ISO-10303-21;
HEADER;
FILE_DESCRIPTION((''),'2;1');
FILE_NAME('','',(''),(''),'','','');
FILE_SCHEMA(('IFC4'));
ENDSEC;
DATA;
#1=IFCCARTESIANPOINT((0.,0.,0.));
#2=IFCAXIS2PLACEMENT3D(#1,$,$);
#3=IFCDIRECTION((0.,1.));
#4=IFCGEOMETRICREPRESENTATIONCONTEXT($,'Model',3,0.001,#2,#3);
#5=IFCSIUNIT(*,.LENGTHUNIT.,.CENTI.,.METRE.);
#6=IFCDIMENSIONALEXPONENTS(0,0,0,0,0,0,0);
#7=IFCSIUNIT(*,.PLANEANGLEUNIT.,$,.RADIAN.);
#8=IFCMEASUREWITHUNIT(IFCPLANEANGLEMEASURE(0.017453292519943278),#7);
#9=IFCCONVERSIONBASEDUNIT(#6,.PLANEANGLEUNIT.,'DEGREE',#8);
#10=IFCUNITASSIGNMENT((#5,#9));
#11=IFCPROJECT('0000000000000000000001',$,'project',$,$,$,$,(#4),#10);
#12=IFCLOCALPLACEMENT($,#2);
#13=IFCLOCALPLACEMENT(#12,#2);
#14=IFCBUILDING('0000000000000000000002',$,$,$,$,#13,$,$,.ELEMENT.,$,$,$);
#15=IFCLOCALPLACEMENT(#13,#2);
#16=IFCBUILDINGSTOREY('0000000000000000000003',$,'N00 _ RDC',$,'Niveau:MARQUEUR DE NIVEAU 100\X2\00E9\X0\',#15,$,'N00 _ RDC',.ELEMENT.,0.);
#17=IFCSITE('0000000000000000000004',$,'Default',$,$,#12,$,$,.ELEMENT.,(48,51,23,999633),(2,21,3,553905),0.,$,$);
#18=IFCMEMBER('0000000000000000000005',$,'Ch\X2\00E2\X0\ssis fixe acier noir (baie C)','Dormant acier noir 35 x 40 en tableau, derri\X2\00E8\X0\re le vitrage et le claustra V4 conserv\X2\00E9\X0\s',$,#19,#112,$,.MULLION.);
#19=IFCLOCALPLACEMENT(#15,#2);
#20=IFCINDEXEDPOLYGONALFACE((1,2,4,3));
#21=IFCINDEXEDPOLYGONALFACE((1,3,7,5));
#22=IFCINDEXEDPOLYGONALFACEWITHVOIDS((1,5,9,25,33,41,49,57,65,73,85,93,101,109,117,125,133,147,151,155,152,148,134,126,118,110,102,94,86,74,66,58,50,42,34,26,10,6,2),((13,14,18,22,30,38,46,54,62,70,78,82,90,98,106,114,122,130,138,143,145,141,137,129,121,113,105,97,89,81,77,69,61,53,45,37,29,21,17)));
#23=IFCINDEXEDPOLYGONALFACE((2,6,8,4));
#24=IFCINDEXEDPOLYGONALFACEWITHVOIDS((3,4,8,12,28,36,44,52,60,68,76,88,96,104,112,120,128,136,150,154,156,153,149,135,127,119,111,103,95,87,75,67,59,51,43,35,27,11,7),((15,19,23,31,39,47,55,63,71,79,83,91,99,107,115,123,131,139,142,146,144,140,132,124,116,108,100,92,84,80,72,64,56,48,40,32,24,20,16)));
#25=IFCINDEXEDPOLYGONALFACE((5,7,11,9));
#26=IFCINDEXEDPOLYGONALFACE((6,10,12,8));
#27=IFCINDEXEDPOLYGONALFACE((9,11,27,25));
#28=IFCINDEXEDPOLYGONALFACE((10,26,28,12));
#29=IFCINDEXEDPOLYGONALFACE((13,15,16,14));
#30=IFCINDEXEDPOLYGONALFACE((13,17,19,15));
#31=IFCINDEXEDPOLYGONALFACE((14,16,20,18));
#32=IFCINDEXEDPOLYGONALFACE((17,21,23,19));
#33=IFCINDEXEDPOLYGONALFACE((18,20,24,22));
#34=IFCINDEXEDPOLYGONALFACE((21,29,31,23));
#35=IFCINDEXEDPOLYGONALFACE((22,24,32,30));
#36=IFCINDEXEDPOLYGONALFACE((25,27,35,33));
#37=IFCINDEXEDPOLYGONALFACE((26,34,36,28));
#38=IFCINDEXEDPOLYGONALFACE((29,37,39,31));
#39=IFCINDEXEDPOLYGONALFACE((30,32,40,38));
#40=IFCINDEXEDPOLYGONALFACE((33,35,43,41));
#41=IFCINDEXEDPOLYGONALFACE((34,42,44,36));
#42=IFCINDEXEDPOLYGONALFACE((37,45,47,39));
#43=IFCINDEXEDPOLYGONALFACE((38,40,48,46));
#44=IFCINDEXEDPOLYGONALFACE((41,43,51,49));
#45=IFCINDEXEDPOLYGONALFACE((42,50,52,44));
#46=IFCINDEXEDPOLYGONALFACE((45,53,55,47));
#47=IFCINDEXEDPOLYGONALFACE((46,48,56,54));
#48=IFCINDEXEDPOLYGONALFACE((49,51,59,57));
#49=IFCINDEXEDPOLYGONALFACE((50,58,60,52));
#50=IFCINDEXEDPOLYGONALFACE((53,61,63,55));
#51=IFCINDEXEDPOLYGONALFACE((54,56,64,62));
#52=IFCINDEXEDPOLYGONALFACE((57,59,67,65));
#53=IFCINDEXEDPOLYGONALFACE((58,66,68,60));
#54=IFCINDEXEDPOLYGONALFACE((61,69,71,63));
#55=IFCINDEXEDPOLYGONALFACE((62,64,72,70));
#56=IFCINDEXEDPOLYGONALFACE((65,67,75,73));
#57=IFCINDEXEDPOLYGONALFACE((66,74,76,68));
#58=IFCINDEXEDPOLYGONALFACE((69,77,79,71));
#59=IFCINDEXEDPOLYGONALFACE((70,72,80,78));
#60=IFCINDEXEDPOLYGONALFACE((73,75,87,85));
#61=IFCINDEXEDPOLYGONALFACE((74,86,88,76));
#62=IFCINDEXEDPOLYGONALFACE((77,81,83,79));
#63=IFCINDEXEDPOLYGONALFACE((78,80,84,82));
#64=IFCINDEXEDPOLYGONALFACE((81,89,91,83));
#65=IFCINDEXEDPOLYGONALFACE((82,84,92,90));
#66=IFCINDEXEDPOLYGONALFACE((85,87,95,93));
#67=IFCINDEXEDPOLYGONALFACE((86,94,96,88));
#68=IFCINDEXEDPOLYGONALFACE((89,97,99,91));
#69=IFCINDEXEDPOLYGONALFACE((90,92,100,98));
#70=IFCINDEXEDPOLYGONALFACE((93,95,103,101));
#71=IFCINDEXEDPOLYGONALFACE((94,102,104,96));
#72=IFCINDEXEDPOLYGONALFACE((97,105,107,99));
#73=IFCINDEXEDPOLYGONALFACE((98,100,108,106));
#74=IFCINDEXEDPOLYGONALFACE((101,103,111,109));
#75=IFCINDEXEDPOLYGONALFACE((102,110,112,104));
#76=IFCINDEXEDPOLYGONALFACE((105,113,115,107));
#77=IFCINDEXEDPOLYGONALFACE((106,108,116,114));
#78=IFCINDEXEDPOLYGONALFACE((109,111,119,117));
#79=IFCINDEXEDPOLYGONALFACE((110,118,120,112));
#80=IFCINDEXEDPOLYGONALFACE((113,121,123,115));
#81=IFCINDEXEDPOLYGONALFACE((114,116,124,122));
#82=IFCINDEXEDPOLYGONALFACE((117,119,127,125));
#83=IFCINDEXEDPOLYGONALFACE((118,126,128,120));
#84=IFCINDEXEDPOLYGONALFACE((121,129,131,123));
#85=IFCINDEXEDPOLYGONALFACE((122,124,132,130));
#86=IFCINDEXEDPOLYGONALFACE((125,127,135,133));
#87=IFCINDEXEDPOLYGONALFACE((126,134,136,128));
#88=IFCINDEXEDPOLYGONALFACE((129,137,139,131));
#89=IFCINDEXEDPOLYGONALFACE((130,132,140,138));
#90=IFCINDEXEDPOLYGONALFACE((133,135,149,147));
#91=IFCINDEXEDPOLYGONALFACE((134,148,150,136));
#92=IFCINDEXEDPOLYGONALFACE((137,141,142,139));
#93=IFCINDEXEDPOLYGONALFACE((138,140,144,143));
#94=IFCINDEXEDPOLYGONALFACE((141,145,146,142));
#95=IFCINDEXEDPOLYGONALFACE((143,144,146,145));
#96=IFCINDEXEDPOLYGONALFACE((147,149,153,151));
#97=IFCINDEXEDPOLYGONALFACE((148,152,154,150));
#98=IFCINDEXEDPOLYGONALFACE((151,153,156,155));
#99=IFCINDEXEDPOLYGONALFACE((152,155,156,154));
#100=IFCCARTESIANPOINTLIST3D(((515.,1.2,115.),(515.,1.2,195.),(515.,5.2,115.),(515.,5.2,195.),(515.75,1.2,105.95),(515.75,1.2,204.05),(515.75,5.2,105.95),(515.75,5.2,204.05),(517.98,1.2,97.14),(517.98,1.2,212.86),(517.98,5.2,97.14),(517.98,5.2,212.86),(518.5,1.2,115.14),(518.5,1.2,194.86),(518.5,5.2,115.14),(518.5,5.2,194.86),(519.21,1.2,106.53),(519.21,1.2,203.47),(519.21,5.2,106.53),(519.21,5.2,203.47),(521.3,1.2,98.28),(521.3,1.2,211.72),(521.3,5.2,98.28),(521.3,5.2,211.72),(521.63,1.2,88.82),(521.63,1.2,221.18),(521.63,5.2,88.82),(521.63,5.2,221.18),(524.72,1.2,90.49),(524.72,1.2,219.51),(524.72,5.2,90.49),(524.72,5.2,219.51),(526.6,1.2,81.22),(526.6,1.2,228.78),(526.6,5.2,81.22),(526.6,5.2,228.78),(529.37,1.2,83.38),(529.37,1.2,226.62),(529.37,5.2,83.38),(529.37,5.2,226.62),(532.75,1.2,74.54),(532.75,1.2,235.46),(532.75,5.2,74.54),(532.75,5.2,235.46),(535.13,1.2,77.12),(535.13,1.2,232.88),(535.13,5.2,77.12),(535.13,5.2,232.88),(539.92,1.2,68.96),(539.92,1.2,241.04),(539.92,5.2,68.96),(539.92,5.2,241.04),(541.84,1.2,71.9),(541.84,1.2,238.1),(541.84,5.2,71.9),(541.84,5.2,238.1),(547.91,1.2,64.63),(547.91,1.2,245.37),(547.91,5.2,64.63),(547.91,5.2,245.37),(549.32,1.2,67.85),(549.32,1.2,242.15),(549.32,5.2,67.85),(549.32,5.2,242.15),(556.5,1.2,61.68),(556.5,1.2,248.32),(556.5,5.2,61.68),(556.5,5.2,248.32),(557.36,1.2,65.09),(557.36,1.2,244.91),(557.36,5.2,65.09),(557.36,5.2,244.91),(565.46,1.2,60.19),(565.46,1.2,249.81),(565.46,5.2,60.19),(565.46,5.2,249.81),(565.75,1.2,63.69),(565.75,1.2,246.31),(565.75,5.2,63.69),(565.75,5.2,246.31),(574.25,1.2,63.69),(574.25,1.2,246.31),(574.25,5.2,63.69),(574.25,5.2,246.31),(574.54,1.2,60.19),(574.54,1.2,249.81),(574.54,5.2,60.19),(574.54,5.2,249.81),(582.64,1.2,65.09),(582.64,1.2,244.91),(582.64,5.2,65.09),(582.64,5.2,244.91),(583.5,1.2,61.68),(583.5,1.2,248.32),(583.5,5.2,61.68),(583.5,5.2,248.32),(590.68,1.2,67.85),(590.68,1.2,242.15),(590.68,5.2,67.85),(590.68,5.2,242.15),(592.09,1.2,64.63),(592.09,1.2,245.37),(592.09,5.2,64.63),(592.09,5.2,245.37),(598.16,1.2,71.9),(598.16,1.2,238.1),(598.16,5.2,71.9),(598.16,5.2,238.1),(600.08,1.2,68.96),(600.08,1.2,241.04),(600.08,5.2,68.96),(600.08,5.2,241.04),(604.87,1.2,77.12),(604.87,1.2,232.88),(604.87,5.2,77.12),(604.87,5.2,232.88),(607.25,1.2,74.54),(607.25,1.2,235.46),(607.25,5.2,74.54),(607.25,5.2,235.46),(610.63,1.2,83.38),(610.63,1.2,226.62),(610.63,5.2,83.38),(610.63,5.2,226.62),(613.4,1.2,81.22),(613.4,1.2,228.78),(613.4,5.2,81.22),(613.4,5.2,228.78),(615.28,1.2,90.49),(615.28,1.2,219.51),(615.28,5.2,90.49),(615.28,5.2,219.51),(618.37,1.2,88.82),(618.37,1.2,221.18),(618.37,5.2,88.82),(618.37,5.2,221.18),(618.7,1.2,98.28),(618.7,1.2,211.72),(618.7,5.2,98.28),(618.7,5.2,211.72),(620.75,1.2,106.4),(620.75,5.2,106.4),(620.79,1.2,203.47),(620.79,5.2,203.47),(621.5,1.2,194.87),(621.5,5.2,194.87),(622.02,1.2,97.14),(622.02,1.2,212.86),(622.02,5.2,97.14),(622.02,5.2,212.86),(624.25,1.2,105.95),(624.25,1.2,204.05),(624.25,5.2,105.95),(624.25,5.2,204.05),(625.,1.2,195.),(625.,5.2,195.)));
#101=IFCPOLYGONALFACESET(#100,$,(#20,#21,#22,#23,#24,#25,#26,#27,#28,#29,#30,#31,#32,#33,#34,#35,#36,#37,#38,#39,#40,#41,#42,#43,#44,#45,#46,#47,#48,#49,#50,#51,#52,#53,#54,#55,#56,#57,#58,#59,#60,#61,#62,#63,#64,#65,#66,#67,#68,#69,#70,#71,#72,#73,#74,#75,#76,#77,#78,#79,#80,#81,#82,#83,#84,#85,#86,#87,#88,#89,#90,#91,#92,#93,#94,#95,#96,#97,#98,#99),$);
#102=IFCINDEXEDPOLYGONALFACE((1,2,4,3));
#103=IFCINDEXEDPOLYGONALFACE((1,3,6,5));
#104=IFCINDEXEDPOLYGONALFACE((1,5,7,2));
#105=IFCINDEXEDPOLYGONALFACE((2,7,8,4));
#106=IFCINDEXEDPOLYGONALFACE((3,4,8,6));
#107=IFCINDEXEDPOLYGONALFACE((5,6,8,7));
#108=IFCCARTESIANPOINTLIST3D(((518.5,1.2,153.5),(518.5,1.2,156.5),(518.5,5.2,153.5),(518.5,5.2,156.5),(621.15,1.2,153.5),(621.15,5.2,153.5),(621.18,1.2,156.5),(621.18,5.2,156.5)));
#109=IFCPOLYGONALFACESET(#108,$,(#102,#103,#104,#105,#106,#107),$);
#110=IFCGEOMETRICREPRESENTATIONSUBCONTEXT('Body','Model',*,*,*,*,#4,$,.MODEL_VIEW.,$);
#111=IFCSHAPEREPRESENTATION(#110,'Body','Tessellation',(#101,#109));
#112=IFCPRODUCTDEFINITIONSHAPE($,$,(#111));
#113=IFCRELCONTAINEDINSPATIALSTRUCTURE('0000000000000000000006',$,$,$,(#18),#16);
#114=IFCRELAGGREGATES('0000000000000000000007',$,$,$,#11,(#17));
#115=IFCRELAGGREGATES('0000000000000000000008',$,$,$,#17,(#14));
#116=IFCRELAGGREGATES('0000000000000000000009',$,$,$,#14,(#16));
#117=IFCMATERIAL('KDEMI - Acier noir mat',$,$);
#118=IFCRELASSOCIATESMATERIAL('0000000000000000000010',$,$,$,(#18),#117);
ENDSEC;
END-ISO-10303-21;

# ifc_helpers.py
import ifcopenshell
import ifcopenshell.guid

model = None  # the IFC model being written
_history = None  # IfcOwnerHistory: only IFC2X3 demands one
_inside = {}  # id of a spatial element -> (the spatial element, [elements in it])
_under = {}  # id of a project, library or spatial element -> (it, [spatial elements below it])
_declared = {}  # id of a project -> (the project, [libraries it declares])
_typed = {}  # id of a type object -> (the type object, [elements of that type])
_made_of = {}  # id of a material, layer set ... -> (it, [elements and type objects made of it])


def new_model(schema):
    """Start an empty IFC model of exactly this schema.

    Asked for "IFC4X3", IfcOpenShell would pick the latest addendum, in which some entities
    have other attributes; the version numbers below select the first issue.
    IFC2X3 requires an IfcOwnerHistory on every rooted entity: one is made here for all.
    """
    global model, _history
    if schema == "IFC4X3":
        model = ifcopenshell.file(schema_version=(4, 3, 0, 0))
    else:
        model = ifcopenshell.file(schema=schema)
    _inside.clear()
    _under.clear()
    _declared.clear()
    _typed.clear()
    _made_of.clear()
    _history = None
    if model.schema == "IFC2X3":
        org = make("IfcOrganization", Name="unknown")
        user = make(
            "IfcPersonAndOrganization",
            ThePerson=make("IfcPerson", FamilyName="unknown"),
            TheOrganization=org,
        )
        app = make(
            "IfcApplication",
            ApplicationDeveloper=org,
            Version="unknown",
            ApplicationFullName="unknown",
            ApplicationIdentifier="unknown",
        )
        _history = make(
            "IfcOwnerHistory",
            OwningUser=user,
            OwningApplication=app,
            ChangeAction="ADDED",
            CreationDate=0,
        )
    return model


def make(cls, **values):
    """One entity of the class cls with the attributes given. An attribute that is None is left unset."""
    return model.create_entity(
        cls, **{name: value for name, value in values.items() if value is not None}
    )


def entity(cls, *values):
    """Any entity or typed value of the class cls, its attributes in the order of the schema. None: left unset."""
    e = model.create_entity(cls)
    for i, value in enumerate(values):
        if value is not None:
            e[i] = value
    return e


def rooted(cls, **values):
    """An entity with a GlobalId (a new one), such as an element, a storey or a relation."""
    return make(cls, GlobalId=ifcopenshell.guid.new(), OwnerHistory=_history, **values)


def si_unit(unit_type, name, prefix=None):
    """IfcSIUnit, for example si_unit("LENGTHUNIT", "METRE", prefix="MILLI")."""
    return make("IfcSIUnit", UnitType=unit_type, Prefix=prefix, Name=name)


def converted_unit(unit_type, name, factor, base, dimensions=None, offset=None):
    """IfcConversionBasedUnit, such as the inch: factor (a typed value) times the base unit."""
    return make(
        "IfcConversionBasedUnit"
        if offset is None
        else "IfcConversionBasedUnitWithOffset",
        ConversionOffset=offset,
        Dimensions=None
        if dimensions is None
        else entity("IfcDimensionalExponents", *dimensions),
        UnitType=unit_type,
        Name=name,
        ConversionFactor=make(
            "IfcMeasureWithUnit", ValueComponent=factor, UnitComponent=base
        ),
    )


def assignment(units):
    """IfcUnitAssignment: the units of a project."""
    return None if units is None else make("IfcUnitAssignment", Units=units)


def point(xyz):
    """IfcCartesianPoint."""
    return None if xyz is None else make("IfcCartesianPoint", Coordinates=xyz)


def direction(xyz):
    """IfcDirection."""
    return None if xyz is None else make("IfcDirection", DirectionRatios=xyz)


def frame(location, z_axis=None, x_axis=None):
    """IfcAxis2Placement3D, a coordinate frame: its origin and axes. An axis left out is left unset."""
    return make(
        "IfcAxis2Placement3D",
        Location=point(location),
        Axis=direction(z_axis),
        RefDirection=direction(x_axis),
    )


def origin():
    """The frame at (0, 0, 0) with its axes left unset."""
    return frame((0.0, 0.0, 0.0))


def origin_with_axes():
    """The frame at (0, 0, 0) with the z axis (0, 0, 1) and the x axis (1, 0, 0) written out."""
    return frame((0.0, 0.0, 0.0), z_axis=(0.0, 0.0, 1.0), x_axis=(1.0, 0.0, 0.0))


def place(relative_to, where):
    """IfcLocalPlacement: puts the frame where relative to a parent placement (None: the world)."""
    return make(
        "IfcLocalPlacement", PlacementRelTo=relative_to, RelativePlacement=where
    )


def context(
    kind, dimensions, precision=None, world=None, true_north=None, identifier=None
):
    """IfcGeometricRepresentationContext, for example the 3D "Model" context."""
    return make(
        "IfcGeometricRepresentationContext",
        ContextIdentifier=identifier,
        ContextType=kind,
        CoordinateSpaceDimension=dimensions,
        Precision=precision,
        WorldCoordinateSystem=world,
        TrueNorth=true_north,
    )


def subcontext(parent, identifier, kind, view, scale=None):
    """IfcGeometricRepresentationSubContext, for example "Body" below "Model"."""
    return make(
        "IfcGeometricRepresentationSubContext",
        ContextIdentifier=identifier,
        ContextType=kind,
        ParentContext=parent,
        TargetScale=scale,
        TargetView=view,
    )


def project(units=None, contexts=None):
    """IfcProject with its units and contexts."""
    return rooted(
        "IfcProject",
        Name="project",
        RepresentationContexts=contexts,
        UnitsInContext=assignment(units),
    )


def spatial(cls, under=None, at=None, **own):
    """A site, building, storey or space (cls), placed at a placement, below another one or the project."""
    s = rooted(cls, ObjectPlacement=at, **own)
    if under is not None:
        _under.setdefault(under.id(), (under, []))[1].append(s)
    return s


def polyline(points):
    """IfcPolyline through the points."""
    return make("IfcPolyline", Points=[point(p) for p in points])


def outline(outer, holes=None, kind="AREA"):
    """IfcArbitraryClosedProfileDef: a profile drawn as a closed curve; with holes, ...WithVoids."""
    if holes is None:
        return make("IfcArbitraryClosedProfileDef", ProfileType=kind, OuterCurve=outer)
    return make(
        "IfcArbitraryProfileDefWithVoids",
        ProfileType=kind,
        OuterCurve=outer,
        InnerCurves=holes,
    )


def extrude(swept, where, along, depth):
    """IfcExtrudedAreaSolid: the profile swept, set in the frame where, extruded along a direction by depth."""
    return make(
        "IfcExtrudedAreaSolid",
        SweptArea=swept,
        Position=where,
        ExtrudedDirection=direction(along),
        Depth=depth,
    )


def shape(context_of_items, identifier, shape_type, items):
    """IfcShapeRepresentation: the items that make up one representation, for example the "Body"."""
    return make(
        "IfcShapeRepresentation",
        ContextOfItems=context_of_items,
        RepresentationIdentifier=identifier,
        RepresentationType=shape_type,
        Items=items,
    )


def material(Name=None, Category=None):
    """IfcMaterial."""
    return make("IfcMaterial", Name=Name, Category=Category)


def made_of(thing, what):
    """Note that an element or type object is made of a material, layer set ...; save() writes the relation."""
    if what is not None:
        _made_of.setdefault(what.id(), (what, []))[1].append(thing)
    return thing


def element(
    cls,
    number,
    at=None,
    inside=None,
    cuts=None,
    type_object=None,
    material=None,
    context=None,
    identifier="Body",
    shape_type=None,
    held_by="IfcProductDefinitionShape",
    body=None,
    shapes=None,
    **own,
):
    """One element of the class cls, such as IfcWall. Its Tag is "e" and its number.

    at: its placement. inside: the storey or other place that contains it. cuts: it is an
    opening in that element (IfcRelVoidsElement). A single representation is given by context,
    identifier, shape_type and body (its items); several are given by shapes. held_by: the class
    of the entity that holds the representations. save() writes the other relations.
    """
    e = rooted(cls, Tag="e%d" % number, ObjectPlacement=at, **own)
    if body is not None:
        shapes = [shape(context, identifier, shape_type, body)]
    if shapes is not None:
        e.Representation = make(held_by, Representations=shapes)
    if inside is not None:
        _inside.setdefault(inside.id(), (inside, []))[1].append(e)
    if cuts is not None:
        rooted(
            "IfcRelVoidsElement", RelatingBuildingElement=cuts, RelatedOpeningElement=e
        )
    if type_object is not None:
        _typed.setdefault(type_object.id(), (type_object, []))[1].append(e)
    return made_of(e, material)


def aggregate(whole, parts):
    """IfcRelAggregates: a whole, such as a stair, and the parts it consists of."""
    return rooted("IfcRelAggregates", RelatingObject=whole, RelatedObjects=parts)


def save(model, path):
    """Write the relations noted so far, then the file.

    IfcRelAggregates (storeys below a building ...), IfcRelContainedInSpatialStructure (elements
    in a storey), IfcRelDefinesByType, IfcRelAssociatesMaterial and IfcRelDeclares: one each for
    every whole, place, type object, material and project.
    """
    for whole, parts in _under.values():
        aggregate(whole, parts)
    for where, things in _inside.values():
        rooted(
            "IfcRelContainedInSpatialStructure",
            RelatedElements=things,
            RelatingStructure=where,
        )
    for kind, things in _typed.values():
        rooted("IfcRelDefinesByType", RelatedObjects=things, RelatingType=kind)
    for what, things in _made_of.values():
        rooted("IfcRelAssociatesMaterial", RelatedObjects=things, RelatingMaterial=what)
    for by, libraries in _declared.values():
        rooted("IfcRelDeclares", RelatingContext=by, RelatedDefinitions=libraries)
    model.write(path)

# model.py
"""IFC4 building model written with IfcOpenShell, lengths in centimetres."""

from ifc_helpers import new_model, entity, si_unit, converted_unit, direction, frame, origin, origin_with_axes, place, context, subcontext, project, spatial, polyline, outline, extrude, material, element, save


model = new_model("IFC4")

# Units and contexts
model_context = context("Model", 3, precision=0.001, world=origin(), true_north=direction((0.0, 1.0)))
body_context = subcontext(model_context, "Body", "Model", "MODEL_VIEW")
ifc_project = project(units=[si_unit("LENGTHUNIT", "METRE", prefix="CENTI"), converted_unit("PLANEANGLEUNIT", "DEGREE", entity("IfcPlaneAngleMeasure", 0.017453292519943278), si_unit("PLANEANGLEUNIT", "RADIAN"), dimensions=[0, 0, 0, 0, 0, 0, 0])], contexts=[model_context])

# Site, building, storey
site_placement = place(None, origin())
site = spatial("IfcSite", under=ifc_project, at=site_placement, Name="Default", CompositionType="ELEMENT", RefLatitude=(48, 51, 23, 999633), RefLongitude=(2, 21, 3, 553905), RefElevation=0.0)
building_placement = place(site_placement, origin())
building = spatial("IfcBuilding", under=site, at=building_placement, CompositionType="ELEMENT")
storey_placement = place(building_placement, origin())
storey = spatial("IfcBuildingStorey", under=building, at=storey_placement, Name="N00 _ RDC", ObjectType="Niveau:MARQUEUR DE NIVEAU 100é", LongName="N00 _ RDC", CompositionType="ELEMENT", Elevation=0.0)

# Member
ifc_material_1 = material(Name="KDEMI - Acier noir mat")
member_1_placement = place(storey_placement, origin_with_axes())
element("IfcMember", 1, at=member_1_placement, inside=storey, material=ifc_material_1, Name="Châssis fixe acier noir (baie C)", Description="Dormant acier noir 35 x 40 en tableau, derrière le vitrage et le claustra V4 conservés", PredefinedType="MULLION", context=body_context, shape_type="SweptSolid", body=[
    extrude(outline(polyline([(624.25, 105.95), (622.02, 97.14), (618.37, 88.82), (613.4, 81.22), (607.25, 74.54), (600.08, 68.96), (592.09, 64.63), (583.5, 61.68), (574.54, 60.19), (565.46, 60.19), (556.5, 61.68), (547.91, 64.63), (539.92, 68.96), (532.75, 74.54), (526.6, 81.22), (521.63, 88.82), (517.98, 97.14), (515.75, 105.95), (515.0, 115.0), (515.0, 195.0), (515.75, 204.05), (517.98, 212.86), (521.63, 221.18), (526.6, 228.78), (532.75, 235.46), (539.92, 241.04), (547.91, 245.37), (556.5, 248.32), (565.46, 249.81), (574.54, 249.81), (583.5, 248.32), (592.09, 245.37), (600.08, 241.04), (607.25, 235.46), (613.4, 228.78), (618.37, 221.18), (622.02, 212.86), (624.25, 204.05), (625.0, 195.0), (624.25, 105.95)]), holes=[polyline([(620.79, 203.47), (618.7, 211.72), (615.28, 219.51), (610.63, 226.62), (604.87, 232.88), (598.16, 238.1), (590.68, 242.15), (582.64, 244.91), (574.25, 246.31), (565.75, 246.31), (557.36, 244.91), (549.32, 242.15), (541.84, 238.1), (535.13, 232.88), (529.37, 226.62), (524.72, 219.51), (521.3, 211.72), (519.21, 203.47), (518.5, 194.86), (518.5, 115.14), (519.21, 106.53), (521.3, 98.28), (524.72, 90.49), (529.37, 83.38), (535.13, 77.12), (541.84, 71.9), (549.32, 67.85), (557.36, 65.09), (565.75, 63.69), (574.25, 63.69), (582.64, 65.09), (590.68, 67.85), (598.16, 71.9), (604.87, 77.12), (610.63, 83.38), (615.28, 90.49), (618.7, 98.28), (620.75, 106.4), (621.5, 194.87), (620.79, 203.47)])]), frame((0.0, 5.2, 0.0), z_axis=(0.0, -1.0, 0.0), x_axis=(1.0, 0.0, 0.0)), (0.0, 0.0, 1.0), 4.0),
    extrude(outline(polyline([(621.18, 156.5), (621.15, 153.5), (518.5, 153.5), (518.5, 156.5), (621.18, 156.5)])), frame((0.0, 5.2, 0.0), z_axis=(0.0, -1.0, 0.0), x_axis=(1.0, 0.0, 0.0)), (0.0, 0.0, 1.0), 4.0),
])

save(model, "model.ifc")
